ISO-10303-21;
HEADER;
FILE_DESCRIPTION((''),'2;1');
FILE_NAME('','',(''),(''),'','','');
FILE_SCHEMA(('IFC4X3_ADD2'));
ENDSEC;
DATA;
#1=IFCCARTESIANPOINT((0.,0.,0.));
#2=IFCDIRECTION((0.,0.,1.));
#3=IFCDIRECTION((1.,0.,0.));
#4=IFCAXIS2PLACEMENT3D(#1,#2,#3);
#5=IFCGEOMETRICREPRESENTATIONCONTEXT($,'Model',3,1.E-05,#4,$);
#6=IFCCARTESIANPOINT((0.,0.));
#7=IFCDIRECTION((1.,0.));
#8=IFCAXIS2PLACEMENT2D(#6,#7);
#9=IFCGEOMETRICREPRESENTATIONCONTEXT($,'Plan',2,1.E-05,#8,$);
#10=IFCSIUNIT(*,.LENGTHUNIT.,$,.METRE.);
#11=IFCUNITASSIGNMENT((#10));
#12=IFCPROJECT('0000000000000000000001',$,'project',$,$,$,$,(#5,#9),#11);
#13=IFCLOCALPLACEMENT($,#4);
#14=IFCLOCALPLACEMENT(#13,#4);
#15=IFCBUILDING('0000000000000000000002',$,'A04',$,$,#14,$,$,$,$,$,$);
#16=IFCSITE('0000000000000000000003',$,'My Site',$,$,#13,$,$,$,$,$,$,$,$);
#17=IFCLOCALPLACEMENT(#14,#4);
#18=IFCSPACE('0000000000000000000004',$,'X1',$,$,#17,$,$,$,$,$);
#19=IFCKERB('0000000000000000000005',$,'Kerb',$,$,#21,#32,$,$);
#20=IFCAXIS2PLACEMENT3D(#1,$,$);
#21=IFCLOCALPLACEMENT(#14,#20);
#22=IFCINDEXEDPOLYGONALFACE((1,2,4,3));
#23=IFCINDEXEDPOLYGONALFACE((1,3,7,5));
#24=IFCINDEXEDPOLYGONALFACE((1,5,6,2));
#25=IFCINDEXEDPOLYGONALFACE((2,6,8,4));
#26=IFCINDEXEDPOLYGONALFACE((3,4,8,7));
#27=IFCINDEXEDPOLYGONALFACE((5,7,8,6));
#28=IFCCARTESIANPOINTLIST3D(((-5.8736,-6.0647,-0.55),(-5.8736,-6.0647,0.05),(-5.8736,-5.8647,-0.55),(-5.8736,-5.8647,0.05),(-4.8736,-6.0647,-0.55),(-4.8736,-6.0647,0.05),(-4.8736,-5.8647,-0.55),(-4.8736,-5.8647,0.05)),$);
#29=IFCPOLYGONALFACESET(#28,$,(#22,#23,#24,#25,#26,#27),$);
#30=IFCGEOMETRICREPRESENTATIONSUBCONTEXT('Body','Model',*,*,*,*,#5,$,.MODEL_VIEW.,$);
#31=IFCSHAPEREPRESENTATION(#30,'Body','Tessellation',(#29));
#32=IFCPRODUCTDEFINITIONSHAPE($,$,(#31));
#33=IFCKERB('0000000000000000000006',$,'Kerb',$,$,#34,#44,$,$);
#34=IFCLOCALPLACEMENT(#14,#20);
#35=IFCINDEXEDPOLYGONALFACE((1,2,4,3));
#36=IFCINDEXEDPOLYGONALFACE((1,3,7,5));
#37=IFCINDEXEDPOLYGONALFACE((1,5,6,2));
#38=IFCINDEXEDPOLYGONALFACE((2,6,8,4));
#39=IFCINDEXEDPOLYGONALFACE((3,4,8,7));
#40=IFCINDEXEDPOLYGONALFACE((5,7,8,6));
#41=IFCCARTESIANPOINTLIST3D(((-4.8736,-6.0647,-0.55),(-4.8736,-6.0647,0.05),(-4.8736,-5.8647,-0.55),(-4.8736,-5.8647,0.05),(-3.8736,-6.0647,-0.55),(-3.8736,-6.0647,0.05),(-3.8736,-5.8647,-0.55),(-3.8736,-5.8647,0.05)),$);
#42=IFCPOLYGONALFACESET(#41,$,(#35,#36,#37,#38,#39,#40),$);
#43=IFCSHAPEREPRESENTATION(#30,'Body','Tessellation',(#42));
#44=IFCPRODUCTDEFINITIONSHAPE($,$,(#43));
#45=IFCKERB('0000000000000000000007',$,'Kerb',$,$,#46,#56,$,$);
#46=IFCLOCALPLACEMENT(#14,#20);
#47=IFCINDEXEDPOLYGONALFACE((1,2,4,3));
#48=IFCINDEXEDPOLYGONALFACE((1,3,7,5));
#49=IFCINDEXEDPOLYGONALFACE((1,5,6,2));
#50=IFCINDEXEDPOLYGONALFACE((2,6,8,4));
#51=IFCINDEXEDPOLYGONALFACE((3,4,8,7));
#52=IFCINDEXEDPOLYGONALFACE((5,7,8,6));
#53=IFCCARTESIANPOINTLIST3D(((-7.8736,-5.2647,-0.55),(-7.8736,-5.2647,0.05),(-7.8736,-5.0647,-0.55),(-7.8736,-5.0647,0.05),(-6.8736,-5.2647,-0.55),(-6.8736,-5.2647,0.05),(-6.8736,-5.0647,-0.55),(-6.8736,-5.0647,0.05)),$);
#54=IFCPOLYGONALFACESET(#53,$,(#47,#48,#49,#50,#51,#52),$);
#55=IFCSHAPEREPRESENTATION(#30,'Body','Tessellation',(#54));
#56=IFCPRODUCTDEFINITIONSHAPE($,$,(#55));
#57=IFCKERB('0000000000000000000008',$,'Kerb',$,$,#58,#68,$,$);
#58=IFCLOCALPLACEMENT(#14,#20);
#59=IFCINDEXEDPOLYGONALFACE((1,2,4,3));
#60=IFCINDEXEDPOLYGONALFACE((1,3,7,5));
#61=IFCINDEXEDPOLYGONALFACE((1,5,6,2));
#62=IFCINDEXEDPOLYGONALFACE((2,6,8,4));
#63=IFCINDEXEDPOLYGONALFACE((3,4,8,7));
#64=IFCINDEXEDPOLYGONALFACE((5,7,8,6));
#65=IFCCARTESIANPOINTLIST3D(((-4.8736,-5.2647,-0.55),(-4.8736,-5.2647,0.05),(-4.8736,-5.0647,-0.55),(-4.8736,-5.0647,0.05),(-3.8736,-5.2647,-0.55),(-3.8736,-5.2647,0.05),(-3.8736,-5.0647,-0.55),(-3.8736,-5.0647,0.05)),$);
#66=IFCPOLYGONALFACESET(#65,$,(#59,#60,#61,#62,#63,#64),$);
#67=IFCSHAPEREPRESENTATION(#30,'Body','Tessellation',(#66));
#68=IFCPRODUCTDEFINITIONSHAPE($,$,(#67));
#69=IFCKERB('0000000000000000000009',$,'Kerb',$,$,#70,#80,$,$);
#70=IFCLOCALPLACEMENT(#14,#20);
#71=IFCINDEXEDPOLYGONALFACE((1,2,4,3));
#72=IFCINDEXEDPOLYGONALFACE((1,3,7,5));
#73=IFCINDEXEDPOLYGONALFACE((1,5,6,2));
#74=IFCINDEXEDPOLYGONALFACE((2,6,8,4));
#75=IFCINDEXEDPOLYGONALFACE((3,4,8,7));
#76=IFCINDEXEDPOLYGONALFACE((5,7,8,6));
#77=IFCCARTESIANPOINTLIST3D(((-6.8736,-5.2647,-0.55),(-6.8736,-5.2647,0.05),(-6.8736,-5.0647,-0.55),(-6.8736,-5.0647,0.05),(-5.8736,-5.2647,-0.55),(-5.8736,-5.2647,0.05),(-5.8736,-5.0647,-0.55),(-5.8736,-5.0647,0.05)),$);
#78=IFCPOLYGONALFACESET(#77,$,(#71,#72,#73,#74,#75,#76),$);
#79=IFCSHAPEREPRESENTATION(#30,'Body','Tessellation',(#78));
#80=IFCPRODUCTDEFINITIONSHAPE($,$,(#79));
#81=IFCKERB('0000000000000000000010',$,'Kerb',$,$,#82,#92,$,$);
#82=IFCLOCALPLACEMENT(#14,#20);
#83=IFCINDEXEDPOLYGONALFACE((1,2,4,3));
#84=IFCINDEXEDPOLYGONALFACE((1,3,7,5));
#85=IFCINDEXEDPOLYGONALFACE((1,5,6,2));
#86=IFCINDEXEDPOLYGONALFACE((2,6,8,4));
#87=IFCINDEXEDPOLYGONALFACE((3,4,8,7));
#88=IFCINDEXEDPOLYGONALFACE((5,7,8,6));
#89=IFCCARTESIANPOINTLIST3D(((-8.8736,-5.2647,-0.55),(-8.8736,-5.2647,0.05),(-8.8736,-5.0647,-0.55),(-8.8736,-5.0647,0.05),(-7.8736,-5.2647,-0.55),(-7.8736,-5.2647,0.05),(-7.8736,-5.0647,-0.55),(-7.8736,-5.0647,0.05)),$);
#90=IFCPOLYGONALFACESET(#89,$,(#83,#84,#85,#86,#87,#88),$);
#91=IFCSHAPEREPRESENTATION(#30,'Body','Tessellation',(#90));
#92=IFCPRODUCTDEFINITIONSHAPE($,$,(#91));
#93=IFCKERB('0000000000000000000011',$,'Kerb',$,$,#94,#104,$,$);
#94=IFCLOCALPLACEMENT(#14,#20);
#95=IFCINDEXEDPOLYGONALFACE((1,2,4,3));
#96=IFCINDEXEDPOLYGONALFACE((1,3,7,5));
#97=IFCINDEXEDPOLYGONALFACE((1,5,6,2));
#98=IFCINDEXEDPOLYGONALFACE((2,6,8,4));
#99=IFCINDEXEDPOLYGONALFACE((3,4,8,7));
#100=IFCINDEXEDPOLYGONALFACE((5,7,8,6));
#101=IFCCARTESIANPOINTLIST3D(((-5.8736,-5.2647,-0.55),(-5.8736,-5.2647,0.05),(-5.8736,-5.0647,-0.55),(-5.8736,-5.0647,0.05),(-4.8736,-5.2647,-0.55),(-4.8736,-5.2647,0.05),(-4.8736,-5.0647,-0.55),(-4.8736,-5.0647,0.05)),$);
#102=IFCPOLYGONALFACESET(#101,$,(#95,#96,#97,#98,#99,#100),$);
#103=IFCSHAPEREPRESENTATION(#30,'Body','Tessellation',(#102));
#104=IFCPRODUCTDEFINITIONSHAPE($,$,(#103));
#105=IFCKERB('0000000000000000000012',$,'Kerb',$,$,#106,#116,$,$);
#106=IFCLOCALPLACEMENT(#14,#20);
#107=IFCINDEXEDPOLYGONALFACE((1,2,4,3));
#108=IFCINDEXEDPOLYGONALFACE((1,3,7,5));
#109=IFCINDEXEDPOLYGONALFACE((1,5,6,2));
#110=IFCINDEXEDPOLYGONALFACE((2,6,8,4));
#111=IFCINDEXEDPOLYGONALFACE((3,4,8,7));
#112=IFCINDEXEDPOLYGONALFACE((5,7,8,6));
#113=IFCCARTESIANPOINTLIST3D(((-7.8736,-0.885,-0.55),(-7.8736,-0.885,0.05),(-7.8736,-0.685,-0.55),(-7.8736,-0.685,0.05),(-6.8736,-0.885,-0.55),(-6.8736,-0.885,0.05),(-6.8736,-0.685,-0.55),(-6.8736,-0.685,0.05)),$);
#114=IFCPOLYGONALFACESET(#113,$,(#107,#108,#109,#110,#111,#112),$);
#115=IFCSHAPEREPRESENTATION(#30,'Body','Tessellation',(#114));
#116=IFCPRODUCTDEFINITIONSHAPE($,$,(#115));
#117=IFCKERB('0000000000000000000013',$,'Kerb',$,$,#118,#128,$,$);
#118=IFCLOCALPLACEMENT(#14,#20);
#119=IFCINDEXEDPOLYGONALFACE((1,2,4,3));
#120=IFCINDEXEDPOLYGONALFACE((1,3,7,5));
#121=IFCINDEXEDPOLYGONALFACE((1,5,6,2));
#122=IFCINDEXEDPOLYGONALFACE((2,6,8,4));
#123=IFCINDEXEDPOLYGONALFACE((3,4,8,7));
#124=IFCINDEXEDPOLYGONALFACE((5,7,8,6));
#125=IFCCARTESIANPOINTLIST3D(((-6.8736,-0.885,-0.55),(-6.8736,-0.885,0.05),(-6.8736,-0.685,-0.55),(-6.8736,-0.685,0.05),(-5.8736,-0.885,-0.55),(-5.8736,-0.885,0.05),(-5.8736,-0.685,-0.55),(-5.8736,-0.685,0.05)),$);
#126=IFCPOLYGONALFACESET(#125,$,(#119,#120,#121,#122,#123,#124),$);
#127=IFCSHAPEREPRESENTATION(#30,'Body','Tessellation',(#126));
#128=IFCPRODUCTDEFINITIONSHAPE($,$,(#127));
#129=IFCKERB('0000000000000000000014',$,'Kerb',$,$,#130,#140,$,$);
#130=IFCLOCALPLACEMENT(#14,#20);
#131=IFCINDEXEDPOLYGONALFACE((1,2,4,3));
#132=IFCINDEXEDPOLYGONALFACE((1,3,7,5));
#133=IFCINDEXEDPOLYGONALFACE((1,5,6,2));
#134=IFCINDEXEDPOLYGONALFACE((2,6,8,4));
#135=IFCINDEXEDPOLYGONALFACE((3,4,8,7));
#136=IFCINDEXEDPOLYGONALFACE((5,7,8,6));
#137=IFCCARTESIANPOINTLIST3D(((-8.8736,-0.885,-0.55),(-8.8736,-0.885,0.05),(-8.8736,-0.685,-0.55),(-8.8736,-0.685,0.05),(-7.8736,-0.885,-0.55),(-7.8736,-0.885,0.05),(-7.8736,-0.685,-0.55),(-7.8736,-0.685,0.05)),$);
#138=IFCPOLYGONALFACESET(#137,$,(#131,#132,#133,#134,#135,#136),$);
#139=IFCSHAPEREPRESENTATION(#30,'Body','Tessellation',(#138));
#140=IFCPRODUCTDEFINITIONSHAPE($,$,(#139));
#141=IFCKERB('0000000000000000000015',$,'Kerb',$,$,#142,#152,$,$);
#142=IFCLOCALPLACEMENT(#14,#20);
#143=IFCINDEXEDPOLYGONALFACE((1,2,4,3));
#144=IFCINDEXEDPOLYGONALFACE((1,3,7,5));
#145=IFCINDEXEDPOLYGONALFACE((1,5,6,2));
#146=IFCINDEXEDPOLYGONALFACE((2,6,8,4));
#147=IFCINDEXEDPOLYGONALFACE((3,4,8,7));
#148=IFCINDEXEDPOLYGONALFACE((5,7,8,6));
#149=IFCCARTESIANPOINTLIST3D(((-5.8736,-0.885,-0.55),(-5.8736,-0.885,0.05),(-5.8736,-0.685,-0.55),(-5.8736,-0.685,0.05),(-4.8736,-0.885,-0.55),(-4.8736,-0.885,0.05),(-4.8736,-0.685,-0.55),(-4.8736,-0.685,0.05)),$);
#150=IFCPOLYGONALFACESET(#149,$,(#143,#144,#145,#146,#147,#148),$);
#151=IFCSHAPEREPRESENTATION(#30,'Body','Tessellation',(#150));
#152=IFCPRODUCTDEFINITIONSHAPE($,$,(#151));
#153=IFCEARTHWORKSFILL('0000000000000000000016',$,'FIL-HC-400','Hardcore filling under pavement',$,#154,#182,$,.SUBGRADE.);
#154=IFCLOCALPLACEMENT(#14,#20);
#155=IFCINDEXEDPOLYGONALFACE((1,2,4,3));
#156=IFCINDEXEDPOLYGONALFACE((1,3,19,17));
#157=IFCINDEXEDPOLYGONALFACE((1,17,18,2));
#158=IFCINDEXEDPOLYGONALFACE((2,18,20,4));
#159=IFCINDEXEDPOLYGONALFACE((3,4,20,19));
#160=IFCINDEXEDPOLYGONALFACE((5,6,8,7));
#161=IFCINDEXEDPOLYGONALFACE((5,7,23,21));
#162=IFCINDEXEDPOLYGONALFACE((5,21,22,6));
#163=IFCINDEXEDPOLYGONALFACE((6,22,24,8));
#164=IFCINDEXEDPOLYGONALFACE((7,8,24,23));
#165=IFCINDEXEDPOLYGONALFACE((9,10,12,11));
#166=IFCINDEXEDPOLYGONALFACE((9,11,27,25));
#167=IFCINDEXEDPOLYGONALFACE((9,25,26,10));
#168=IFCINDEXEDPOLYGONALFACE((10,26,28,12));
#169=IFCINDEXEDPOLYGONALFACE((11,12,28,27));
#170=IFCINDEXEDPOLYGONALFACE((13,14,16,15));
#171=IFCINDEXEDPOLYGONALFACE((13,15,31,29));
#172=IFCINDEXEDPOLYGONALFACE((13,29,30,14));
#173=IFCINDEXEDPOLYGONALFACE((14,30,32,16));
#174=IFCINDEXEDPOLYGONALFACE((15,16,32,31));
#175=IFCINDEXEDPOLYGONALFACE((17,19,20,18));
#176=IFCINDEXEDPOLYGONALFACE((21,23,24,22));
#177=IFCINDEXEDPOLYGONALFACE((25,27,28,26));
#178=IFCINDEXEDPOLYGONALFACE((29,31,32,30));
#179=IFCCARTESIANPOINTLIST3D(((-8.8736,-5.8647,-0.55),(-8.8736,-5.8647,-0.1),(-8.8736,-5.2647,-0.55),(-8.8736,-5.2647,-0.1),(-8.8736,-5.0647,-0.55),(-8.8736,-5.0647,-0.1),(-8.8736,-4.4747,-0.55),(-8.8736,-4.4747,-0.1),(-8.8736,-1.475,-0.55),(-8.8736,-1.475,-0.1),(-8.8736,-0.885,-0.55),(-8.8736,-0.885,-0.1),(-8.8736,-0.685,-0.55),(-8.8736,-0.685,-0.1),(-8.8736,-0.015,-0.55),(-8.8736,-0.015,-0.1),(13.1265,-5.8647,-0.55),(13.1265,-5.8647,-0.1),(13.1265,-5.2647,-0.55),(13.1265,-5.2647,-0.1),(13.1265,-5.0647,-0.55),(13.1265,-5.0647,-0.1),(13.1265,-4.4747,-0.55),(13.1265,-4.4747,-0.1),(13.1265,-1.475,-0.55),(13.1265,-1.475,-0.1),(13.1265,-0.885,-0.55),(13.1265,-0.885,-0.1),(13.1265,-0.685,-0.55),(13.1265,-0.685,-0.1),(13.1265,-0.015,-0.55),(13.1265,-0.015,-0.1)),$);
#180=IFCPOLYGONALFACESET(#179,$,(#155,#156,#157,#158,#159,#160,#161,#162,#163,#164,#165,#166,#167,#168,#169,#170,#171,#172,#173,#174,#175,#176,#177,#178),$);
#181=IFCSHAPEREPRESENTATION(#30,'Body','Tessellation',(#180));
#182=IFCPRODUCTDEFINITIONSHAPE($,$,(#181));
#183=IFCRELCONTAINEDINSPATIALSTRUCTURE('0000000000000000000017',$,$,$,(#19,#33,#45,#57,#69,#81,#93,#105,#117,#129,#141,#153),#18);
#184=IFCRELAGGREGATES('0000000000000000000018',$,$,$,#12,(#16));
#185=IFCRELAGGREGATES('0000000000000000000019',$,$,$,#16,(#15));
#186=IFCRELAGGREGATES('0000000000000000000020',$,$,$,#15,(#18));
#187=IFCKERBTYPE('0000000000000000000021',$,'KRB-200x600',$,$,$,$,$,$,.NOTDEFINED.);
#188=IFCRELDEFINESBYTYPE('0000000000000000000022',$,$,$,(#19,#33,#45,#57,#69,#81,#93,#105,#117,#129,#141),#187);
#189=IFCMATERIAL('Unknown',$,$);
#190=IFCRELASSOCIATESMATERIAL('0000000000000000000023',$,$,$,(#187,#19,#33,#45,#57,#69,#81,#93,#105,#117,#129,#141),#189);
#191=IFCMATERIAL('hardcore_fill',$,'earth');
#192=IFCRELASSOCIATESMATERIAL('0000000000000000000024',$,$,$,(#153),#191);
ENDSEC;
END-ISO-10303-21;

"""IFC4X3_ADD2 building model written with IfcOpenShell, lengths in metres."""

from ifc_helpers import new_model, si_unit, frame, origin_with_axes, origin_2d_with_axis, place, context, subcontext, project, spatial, indexed_curve, rectangle, outline, composite_profile, extrude, material, material_profile, profile_set, profile_usage, type_object, element, save


model = new_model("IFC4X3_ADD2")

# Units and contexts
model_context = context("Model", 3, precision=1e-05, world=origin_with_axes())
plan_context = context("Plan", 2, precision=1e-05, world=origin_2d_with_axis())
body_context = subcontext(model_context, "Body", "Model", "MODEL_VIEW")
ifc_project = project(units=[si_unit("LENGTHUNIT", "METRE")], contexts=[model_context, plan_context])

# Site, building, space
site_placement = place(None, origin_with_axes())
site = spatial("IfcSite", under=ifc_project, at=site_placement, Name="My Site")
building_placement = place(site_placement, origin_with_axes())
building = spatial("IfcBuilding", under=site, at=building_placement, Name="A04")
space_placement = place(building_placement, origin_with_axes())
space = spatial("IfcSpace", under=building, at=space_placement, Name="X1")

# Shared definitions
ifc_material_1 = material(Name="Unknown")

# Kerbs
ifc_material_profile_1 = material_profile(ifc_material_1, rectangle(XDim=0.2, YDim=0.6))
ifc_profile_set_1 = profile_set([ifc_material_profile_1])
kerb_type = type_object("IfcKerbType", Name="KRB-200x600", PredefinedType="NOTDEFINED", material=ifc_profile_set_1)
ifc_profile_usage_1 = profile_usage(ifc_profile_set_1, cardinal=2)
kerb_1_placement = place(space_placement, frame((-5.8736, -5.9647, -0.55), z_axis=(1.0, 0.0, 0.0), x_axis=(0.0, 1.0, 0.0)))
element("IfcKerb", 1, at=kerb_1_placement, inside=space, type_object=kerb_type, material=ifc_profile_usage_1, Name="Kerb", context=body_context, shape_type="SweptSolid", body=[
    extrude(rectangle(XDim=0.2, YDim=0.6), frame((0.0, 0.3, 0.0), z_axis=(0.0, 0.0, 1.0), x_axis=(1.0, 0.0, 0.0)), (0.0, 0.0, 1.0), 1.0),
])
ifc_profile_usage_2 = profile_usage(ifc_profile_set_1, cardinal=2)
kerb_2_placement = place(space_placement, frame((-4.8736, -5.9647, -0.55), z_axis=(1.0, 0.0, 0.0), x_axis=(0.0, 1.0, 0.0)))
element("IfcKerb", 2, at=kerb_2_placement, inside=space, type_object=kerb_type, material=ifc_profile_usage_2, Name="Kerb", context=body_context, shape_type="SweptSolid", body=[
    extrude(rectangle(XDim=0.2, YDim=0.6), frame((0.0, 0.3, 0.0), z_axis=(0.0, 0.0, 1.0), x_axis=(1.0, 0.0, 0.0)), (0.0, 0.0, 1.0), 1.0),
])
ifc_profile_usage_3 = profile_usage(ifc_profile_set_1, cardinal=2)
kerb_3_placement = place(space_placement, frame((-7.8736, -5.1647, -0.55), z_axis=(1.0, 0.0, 0.0), x_axis=(0.0, 1.0, 0.0)))
element("IfcKerb", 3, at=kerb_3_placement, inside=space, type_object=kerb_type, material=ifc_profile_usage_3, Name="Kerb", context=body_context, shape_type="SweptSolid", body=[
    extrude(rectangle(XDim=0.2, YDim=0.6), frame((0.0, 0.3, 0.0), z_axis=(0.0, 0.0, 1.0), x_axis=(1.0, 0.0, 0.0)), (0.0, 0.0, 1.0), 1.0),
])
ifc_profile_usage_4 = profile_usage(ifc_profile_set_1, cardinal=2)
kerb_4_placement = place(space_placement, frame((-4.8736, -5.1647, -0.55), z_axis=(1.0, 0.0, 0.0), x_axis=(0.0, 1.0, 0.0)))
element("IfcKerb", 4, at=kerb_4_placement, inside=space, type_object=kerb_type, material=ifc_profile_usage_4, Name="Kerb", context=body_context, shape_type="SweptSolid", body=[
    extrude(rectangle(XDim=0.2, YDim=0.6), frame((0.0, 0.3, 0.0), z_axis=(0.0, 0.0, 1.0), x_axis=(1.0, 0.0, 0.0)), (0.0, 0.0, 1.0), 1.0),
])
ifc_profile_usage_5 = profile_usage(ifc_profile_set_1, cardinal=2)
kerb_5_placement = place(space_placement, frame((-6.8736, -5.1647, -0.55), z_axis=(1.0, 0.0, 0.0), x_axis=(0.0, 1.0, 0.0)))
element("IfcKerb", 5, at=kerb_5_placement, inside=space, type_object=kerb_type, material=ifc_profile_usage_5, Name="Kerb", context=body_context, shape_type="SweptSolid", body=[
    extrude(rectangle(XDim=0.2, YDim=0.6), frame((0.0, 0.3, 0.0), z_axis=(0.0, 0.0, 1.0), x_axis=(1.0, 0.0, 0.0)), (0.0, 0.0, 1.0), 1.0),
])
ifc_profile_usage_6 = profile_usage(ifc_profile_set_1, cardinal=2)
kerb_6_placement = place(space_placement, frame((-8.8736, -5.1647, -0.55), z_axis=(1.0, 0.0, 0.0), x_axis=(0.0, 1.0, 0.0)))
element("IfcKerb", 6, at=kerb_6_placement, inside=space, type_object=kerb_type, material=ifc_profile_usage_6, Name="Kerb", context=body_context, shape_type="SweptSolid", body=[
    extrude(rectangle(XDim=0.2, YDim=0.6), frame((0.0, 0.3, 0.0), z_axis=(0.0, 0.0, 1.0), x_axis=(1.0, 0.0, 0.0)), (0.0, 0.0, 1.0), 1.0),
])
ifc_profile_usage_7 = profile_usage(ifc_profile_set_1, cardinal=2)
kerb_7_placement = place(space_placement, frame((-5.8736, -5.1647, -0.55), z_axis=(1.0, 0.0, 0.0), x_axis=(0.0, 1.0, 0.0)))
element("IfcKerb", 7, at=kerb_7_placement, inside=space, type_object=kerb_type, material=ifc_profile_usage_7, Name="Kerb", context=body_context, shape_type="SweptSolid", body=[
    extrude(rectangle(XDim=0.2, YDim=0.6), frame((0.0, 0.3, 0.0), z_axis=(0.0, 0.0, 1.0), x_axis=(1.0, 0.0, 0.0)), (0.0, 0.0, 1.0), 1.0),
])
ifc_profile_usage_8 = profile_usage(ifc_profile_set_1, cardinal=2)
kerb_8_placement = place(space_placement, frame((-7.8736, -0.785, -0.55), z_axis=(1.0, 0.0, 0.0), x_axis=(0.0, 1.0, 0.0)))
element("IfcKerb", 8, at=kerb_8_placement, inside=space, type_object=kerb_type, material=ifc_profile_usage_8, Name="Kerb", context=body_context, shape_type="SweptSolid", body=[
    extrude(rectangle(XDim=0.2, YDim=0.6), frame((0.0, 0.3, 0.0), z_axis=(0.0, 0.0, 1.0), x_axis=(1.0, 0.0, 0.0)), (0.0, 0.0, 1.0), 1.0),
])
ifc_profile_usage_9 = profile_usage(ifc_profile_set_1, cardinal=2)
kerb_9_placement = place(space_placement, frame((-6.8736, -0.785, -0.55), z_axis=(1.0, 0.0, 0.0), x_axis=(0.0, 1.0, 0.0)))
element("IfcKerb", 9, at=kerb_9_placement, inside=space, type_object=kerb_type, material=ifc_profile_usage_9, Name="Kerb", context=body_context, shape_type="SweptSolid", body=[
    extrude(rectangle(XDim=0.2, YDim=0.6), frame((0.0, 0.3, 0.0), z_axis=(0.0, 0.0, 1.0), x_axis=(1.0, 0.0, 0.0)), (0.0, 0.0, 1.0), 1.0),
])
ifc_profile_usage_10 = profile_usage(ifc_profile_set_1, cardinal=2)
kerb_10_placement = place(space_placement, frame((-8.8736, -0.785, -0.55), z_axis=(1.0, 0.0, 0.0), x_axis=(0.0, 1.0, 0.0)))
element("IfcKerb", 10, at=kerb_10_placement, inside=space, type_object=kerb_type, material=ifc_profile_usage_10, Name="Kerb", context=body_context, shape_type="SweptSolid", body=[
    extrude(rectangle(XDim=0.2, YDim=0.6), frame((0.0, 0.3, 0.0), z_axis=(0.0, 0.0, 1.0), x_axis=(1.0, 0.0, 0.0)), (0.0, 0.0, 1.0), 1.0),
])
ifc_profile_usage_11 = profile_usage(ifc_profile_set_1, cardinal=2)
kerb_11_placement = place(space_placement, frame((-5.8736, -0.785, -0.55), z_axis=(1.0, 0.0, 0.0), x_axis=(0.0, 1.0, 0.0)))
element("IfcKerb", 11, at=kerb_11_placement, inside=space, type_object=kerb_type, material=ifc_profile_usage_11, Name="Kerb", context=body_context, shape_type="SweptSolid", body=[
    extrude(rectangle(XDim=0.2, YDim=0.6), frame((0.0, 0.3, 0.0), z_axis=(0.0, 0.0, 1.0), x_axis=(1.0, 0.0, 0.0)), (0.0, 0.0, 1.0), 1.0),
])

# Earthworks fill
ifc_material_2 = material(Name="hardcore_fill", Category="earth")
earthworks_fill_placement = place(space_placement, frame((-8.8736, -5.8647, -0.55), z_axis=(0.0, 0.0, 1.0), x_axis=(1.0, 0.0, 0.0)))
element("IfcEarthworksFill", 12, at=earthworks_fill_placement, inside=space, material=ifc_material_2, Name="FIL-HC-400", Description="Hardcore filling under pavement", PredefinedType="SUBGRADE", context=body_context, shape_type="SweptSolid", body=[
    extrude(composite_profile([outline(indexed_curve([(0.0, 4.3897), (22.0, 4.3897), (22.0, 4.9797), (0.0, 4.9797), (0.0, 4.3897)])), outline(indexed_curve([(0.0, 0.8), (22.0, 0.8), (22.0, 1.39), (0.0, 1.39), (0.0, 0.8)])), outline(indexed_curve([(0.0, 0.0), (22.0, 0.0), (22.0, 0.6), (0.0, 0.6), (0.0, 0.0)])), outline(indexed_curve([(0.0, 5.1797), (22.0, 5.1797), (22.0, 5.8497), (0.0, 5.8497), (0.0, 5.1797)]))]), origin_with_axes(), (0.0, 0.0, 1.0), 0.45),
])

save(model, "model.ifc")
